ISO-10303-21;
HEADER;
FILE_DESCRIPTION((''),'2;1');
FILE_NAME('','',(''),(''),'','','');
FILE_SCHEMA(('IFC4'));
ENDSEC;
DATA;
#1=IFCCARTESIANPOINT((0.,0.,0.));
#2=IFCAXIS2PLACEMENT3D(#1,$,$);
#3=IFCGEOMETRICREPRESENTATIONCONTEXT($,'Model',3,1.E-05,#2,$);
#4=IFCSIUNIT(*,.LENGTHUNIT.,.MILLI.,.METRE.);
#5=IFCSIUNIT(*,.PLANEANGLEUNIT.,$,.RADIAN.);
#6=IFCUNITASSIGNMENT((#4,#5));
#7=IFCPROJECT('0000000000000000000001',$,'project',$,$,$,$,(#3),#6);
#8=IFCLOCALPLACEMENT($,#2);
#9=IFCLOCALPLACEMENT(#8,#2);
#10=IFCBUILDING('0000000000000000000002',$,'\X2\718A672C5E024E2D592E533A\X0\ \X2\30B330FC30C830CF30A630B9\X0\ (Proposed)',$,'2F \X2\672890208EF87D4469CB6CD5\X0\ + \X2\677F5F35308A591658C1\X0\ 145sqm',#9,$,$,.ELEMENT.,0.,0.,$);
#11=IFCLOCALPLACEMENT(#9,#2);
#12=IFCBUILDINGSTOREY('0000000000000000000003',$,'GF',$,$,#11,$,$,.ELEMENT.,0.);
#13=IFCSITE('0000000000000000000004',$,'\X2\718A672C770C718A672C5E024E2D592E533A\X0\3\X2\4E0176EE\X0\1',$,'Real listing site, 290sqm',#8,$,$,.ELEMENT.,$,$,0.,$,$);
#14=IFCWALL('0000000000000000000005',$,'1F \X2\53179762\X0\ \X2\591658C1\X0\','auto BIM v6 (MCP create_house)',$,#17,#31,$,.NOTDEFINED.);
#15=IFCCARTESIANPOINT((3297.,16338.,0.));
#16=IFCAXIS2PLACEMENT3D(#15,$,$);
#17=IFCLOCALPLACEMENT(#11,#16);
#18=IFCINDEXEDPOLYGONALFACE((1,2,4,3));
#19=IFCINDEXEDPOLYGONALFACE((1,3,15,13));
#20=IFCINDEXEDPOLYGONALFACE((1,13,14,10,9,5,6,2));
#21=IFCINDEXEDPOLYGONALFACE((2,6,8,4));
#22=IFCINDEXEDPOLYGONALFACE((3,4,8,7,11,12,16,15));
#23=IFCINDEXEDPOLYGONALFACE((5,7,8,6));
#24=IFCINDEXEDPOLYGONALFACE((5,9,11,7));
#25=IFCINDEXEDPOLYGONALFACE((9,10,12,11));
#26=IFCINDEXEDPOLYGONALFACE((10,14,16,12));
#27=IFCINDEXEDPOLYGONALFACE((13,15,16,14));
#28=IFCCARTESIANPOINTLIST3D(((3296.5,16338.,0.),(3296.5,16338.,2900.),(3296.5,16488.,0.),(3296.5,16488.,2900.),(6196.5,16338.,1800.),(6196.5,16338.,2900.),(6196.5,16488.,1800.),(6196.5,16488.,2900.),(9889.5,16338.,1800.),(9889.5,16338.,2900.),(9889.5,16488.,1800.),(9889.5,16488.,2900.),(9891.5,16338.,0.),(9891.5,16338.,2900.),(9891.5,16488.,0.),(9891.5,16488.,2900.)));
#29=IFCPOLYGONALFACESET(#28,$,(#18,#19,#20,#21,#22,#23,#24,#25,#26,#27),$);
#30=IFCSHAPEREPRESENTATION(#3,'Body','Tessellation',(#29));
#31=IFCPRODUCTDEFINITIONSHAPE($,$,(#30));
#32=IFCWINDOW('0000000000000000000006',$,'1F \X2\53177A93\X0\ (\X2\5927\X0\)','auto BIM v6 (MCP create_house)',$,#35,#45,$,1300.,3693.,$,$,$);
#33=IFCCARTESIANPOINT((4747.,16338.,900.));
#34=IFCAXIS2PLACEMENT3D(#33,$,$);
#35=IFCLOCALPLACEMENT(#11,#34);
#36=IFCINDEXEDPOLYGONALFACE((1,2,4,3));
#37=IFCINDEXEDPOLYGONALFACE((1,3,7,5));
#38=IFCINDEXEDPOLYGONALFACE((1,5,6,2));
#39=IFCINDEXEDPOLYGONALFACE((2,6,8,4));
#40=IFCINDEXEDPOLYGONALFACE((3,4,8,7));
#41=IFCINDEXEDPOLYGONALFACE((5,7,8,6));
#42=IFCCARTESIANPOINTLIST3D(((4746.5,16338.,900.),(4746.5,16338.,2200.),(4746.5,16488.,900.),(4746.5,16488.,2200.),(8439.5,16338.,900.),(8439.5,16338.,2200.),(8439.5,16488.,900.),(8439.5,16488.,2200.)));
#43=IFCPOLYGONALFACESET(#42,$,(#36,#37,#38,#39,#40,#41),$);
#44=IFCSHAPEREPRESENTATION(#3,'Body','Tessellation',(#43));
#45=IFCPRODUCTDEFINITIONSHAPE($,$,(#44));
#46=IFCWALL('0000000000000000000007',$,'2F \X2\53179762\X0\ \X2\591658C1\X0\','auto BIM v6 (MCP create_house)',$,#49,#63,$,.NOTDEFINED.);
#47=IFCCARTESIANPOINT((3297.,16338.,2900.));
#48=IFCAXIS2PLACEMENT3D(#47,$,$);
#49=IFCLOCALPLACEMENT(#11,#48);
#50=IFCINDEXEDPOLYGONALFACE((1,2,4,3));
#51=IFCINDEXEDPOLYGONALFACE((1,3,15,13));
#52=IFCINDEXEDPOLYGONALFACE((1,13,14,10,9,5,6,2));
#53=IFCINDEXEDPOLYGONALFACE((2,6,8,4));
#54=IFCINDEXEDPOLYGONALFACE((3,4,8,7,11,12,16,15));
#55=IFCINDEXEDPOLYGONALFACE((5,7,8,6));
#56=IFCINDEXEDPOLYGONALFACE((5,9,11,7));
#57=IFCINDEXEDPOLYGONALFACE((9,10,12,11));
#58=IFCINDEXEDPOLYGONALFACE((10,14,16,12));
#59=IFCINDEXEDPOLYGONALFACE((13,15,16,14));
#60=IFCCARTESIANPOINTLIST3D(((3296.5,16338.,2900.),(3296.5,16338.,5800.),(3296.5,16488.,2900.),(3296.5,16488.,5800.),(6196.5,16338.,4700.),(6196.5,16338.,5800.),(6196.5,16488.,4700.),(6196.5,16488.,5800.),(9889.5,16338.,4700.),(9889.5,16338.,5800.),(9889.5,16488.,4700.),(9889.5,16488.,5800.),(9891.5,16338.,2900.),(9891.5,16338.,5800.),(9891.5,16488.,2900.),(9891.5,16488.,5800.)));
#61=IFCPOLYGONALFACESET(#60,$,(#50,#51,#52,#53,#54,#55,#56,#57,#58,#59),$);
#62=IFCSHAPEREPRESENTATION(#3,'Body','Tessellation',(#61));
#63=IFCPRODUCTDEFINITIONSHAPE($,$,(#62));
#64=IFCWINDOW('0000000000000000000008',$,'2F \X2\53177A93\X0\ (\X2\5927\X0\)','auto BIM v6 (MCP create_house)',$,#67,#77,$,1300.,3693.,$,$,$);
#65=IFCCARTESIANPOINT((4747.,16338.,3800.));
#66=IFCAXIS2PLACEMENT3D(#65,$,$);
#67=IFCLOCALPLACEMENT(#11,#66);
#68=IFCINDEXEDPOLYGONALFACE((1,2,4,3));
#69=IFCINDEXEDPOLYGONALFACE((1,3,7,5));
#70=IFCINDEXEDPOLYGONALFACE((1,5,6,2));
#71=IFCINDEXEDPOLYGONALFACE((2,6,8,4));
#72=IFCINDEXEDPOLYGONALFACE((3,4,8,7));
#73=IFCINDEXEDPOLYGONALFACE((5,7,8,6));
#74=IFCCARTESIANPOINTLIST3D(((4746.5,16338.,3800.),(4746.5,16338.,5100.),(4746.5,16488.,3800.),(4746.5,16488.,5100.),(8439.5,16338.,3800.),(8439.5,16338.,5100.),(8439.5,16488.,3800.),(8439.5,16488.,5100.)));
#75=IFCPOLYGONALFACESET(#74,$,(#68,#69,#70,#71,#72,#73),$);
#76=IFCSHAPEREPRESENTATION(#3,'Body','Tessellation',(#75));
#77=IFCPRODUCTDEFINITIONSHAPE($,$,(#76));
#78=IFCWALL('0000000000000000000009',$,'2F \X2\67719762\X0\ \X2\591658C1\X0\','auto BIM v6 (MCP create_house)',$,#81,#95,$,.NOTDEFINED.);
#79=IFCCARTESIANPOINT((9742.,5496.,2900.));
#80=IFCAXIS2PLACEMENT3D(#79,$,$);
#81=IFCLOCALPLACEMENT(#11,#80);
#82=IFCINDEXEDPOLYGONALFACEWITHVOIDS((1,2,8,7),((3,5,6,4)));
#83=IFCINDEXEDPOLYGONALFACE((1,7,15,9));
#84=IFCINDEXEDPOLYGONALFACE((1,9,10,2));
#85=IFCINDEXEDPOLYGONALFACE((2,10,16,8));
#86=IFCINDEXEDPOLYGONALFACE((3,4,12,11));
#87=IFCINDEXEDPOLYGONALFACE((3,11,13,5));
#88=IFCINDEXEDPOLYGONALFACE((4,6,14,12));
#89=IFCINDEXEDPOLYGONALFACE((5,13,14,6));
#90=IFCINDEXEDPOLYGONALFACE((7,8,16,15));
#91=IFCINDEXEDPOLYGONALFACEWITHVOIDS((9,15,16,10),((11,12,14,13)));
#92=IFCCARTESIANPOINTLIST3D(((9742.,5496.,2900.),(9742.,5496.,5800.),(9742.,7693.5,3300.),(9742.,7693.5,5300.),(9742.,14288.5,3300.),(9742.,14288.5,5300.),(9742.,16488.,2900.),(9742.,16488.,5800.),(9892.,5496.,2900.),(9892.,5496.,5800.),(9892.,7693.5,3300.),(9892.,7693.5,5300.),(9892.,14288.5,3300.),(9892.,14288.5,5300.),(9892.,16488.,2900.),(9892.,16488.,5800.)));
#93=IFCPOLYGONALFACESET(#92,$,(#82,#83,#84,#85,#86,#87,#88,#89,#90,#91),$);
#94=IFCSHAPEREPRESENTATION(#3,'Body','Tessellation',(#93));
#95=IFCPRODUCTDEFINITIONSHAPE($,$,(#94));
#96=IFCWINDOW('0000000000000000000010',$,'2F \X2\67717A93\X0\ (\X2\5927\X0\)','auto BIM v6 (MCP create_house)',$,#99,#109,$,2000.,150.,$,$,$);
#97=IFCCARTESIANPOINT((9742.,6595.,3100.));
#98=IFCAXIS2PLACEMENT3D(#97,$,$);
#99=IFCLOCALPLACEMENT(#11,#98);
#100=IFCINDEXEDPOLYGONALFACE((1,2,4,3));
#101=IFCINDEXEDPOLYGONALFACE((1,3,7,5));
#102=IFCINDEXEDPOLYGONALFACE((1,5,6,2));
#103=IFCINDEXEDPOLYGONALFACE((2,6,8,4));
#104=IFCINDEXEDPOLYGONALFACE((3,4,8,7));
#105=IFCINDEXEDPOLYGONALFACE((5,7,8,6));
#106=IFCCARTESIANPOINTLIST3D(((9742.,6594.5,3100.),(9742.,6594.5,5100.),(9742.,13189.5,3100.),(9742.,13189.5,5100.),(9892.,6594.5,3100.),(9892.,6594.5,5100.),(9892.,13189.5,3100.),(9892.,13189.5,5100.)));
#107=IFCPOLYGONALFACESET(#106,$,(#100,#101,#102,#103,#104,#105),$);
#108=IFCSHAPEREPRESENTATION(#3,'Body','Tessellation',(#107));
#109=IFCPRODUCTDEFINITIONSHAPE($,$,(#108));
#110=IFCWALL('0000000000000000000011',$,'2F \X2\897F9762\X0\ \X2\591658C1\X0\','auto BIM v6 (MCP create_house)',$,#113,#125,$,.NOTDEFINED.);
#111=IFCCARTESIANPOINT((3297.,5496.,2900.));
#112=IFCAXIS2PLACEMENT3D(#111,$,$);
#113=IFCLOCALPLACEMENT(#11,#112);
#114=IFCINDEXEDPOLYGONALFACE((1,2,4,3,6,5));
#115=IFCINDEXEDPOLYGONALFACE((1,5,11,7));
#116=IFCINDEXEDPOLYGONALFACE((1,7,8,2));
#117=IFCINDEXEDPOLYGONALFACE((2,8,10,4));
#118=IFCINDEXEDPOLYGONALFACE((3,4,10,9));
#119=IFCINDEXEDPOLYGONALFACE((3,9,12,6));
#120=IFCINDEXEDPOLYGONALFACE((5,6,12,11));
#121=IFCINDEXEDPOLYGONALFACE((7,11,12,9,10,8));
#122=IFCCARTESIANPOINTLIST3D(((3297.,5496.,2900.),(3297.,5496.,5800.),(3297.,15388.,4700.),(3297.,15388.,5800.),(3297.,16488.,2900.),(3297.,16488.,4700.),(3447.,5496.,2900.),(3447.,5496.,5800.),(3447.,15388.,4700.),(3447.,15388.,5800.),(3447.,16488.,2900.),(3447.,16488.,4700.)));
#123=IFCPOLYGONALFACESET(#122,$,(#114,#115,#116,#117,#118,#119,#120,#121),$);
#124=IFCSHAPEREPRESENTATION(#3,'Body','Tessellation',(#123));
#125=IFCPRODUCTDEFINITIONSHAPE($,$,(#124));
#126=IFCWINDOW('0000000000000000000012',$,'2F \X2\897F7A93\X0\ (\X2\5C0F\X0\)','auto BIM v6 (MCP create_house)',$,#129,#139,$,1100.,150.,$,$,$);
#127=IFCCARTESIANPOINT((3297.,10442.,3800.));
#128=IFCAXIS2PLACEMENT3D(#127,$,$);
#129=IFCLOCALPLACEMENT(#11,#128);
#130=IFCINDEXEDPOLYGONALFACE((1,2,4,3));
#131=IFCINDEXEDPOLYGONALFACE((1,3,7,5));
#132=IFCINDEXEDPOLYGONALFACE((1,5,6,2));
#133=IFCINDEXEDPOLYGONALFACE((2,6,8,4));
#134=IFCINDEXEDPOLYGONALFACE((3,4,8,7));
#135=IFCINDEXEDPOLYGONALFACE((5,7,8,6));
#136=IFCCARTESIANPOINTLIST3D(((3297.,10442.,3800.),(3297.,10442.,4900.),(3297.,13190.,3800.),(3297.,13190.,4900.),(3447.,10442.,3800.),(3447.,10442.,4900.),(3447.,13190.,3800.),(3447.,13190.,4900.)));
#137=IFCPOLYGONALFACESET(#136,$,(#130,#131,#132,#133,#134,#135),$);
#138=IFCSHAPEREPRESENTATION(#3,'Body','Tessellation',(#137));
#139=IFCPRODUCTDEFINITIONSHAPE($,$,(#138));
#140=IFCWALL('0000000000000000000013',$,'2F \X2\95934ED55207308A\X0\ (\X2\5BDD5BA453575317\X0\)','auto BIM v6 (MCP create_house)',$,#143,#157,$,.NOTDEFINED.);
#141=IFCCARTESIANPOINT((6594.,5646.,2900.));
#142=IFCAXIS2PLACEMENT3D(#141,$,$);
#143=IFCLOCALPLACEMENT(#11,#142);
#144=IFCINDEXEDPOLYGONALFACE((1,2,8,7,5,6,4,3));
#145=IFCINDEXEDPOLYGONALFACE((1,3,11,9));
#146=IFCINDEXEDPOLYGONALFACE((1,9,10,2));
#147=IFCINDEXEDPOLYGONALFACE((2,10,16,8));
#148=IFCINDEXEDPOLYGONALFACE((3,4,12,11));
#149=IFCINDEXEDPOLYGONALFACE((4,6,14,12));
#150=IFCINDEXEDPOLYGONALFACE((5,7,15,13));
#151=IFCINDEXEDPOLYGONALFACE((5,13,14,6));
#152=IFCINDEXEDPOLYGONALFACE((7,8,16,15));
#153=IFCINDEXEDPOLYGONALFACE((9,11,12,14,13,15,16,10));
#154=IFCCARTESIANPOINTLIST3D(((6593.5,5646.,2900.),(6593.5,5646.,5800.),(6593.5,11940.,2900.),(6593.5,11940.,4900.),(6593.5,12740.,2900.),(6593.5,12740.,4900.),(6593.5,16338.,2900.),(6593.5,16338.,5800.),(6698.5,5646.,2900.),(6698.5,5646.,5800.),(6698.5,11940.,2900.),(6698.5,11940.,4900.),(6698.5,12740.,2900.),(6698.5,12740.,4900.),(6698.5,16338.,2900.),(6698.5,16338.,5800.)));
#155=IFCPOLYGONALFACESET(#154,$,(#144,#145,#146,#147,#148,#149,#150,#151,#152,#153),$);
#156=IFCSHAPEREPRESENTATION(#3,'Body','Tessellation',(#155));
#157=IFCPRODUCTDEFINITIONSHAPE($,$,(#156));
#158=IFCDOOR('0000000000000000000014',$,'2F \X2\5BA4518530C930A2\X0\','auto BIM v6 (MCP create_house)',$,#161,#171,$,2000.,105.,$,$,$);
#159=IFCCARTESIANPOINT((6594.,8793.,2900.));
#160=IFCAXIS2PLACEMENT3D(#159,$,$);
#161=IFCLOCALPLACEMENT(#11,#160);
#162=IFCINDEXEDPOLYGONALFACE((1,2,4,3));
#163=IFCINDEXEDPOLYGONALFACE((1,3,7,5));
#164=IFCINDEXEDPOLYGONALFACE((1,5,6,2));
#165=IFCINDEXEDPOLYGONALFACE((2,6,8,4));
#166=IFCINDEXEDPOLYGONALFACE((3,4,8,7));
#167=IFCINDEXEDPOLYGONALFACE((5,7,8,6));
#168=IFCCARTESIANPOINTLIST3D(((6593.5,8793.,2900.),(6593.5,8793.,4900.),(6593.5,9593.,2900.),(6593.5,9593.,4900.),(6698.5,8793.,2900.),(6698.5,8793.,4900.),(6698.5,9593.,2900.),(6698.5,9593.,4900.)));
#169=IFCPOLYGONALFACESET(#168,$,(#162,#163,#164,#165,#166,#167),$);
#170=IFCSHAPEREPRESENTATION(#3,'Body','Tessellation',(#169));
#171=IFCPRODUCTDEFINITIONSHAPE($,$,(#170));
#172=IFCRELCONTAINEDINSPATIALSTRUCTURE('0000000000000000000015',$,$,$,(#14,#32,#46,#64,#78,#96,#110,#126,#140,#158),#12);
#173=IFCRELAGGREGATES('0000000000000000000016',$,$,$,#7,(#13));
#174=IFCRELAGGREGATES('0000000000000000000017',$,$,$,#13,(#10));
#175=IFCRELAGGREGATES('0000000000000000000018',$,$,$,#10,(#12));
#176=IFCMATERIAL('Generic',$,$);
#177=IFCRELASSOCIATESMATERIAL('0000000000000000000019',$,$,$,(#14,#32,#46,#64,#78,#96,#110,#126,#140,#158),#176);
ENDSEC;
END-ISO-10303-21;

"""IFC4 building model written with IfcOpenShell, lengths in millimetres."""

from ifc_helpers import new_model, si_unit, frame, frame_2d, origin, place, context, project, spatial, rectangle, extrude, material, element, fill, save


model = new_model("IFC4")

# Units and contexts
model_context = context("Model", 3, precision=1e-05, world=origin())
ifc_project = project(units=[si_unit("LENGTHUNIT", "METRE", prefix="MILLI"), si_unit("PLANEANGLEUNIT", "RADIAN")], contexts=[model_context])

# Site, building, storey
site_placement = place(None, origin())
site = spatial("IfcSite", under=ifc_project, at=site_placement, Name="熊本県熊本市中央区3丁目1", ObjectType="Real listing site, 290sqm", CompositionType="ELEMENT", RefElevation=0.0)
building_placement = place(site_placement, origin())
building = spatial("IfcBuilding", under=site, at=building_placement, Name="熊本市中央区 コートハウス (Proposed)", ObjectType="2F 木造軸組構法 + 板張り外壁 145sqm", CompositionType="ELEMENT", ElevationOfRefHeight=0.0, ElevationOfTerrain=0.0)
storey_placement = place(building_placement, origin())
storey = spatial("IfcBuildingStorey", under=building, at=storey_placement, Name="GF", CompositionType="ELEMENT", Elevation=0.0)

# Wall, opening, window
ifc_material = material(Name="Generic")
wall_1_placement = place(storey_placement, frame((3297.0, 16338.0, 0.0)))
wall_1 = element("IfcWall", 1, at=wall_1_placement, inside=storey, material=ifc_material, Name="1F 北面 外壁", Description="auto BIM v6 (MCP create_house)", PredefinedType="NOTDEFINED", context=model_context, shape_type="SweptSolid", body=[
    extrude(rectangle(XDim=6595.0, YDim=150.0, at=frame_2d((3297.0, 75.0))), frame((3297.0, 16338.0, 0.0)), (0.0, 0.0, 1.0), 2900.0),
])
opening_1_placement = place(storey_placement, frame((4747.0, 16338.0, 900.0)))
opening_1 = element("IfcOpeningElement", 2, at=opening_1_placement, cuts=wall_1, PredefinedType="NOTDEFINED", context=model_context, shape_type="SweptSolid", body=[
    extrude(rectangle(XDim=3693.0, YDim=150.0, at=frame_2d((1846.0, 75.0))), frame((4747.0, 16338.0, 900.0)), (0.0, 0.0, 1.0), 1300.0),
])
window_1_placement = place(storey_placement, frame((4747.0, 16338.0, 900.0)))
window_1 = element("IfcWindow", 3, at=window_1_placement, inside=storey, material=ifc_material, Name="1F 北窓 (大)", Description="auto BIM v6 (MCP create_house)", OverallHeight=1300.0, OverallWidth=3693.0, context=model_context, shape_type="SweptSolid", body=[
    extrude(rectangle(XDim=3693.0, YDim=150.0, at=frame_2d((1846.0, 75.0))), frame((4747.0, 16338.0, 900.0)), (0.0, 0.0, 1.0), 1300.0),
])
fill(opening_1, window_1)

# Walls, openings, windows
wall_2_placement = place(storey_placement, frame((3297.0, 16338.0, 2900.0)))
wall_2 = element("IfcWall", 4, at=wall_2_placement, inside=storey, material=ifc_material, Name="2F 北面 外壁", Description="auto BIM v6 (MCP create_house)", PredefinedType="NOTDEFINED", context=model_context, shape_type="SweptSolid", body=[
    extrude(rectangle(XDim=6595.0, YDim=150.0, at=frame_2d((3297.0, 75.0))), frame((3297.0, 16338.0, 2900.0)), (0.0, 0.0, 1.0), 2900.0),
])
opening_2_placement = place(storey_placement, frame((4747.0, 16338.0, 3800.0)))
opening_2 = element("IfcOpeningElement", 5, at=opening_2_placement, cuts=wall_2, PredefinedType="NOTDEFINED", context=model_context, shape_type="SweptSolid", body=[
    extrude(rectangle(XDim=3693.0, YDim=150.0, at=frame_2d((1846.0, 75.0))), frame((4747.0, 16338.0, 3800.0)), (0.0, 0.0, 1.0), 1300.0),
])
window_2_placement = place(storey_placement, frame((4747.0, 16338.0, 3800.0)))
window_2 = element("IfcWindow", 6, at=window_2_placement, inside=storey, material=ifc_material, Name="2F 北窓 (大)", Description="auto BIM v6 (MCP create_house)", OverallHeight=1300.0, OverallWidth=3693.0, context=model_context, shape_type="SweptSolid", body=[
    extrude(rectangle(XDim=3693.0, YDim=150.0, at=frame_2d((1846.0, 75.0))), frame((4747.0, 16338.0, 3800.0)), (0.0, 0.0, 1.0), 1300.0),
])
fill(opening_2, window_2)
wall_3_placement = place(storey_placement, frame((9742.0, 5496.0, 2900.0)))
wall_3 = element("IfcWall", 7, at=wall_3_placement, inside=storey, material=ifc_material, Name="2F 東面 外壁", Description="auto BIM v6 (MCP create_house)", PredefinedType="NOTDEFINED", context=model_context, shape_type="SweptSolid", body=[
    extrude(rectangle(XDim=150.0, YDim=10992.0, at=frame_2d((75.0, 5496.0))), frame((9742.0, 5496.0, 2900.0)), (0.0, 0.0, 1.0), 2900.0),
])
opening_3_placement = place(storey_placement, frame((9742.0, 6595.0, 3100.0)))
opening_3 = element("IfcOpeningElement", 8, at=opening_3_placement, cuts=wall_3, PredefinedType="NOTDEFINED", context=model_context, shape_type="SweptSolid", body=[
    extrude(rectangle(XDim=150.0, YDim=6595.0, at=frame_2d((75.0, 3297.0))), frame((9742.0, 6595.0, 3100.0)), (0.0, 0.0, 1.0), 2000.0),
])
window_3_placement = place(storey_placement, frame((9742.0, 6595.0, 3100.0)))
window_3 = element("IfcWindow", 9, at=window_3_placement, inside=storey, material=ifc_material, Name="2F 東窓 (大)", Description="auto BIM v6 (MCP create_house)", OverallHeight=2000.0, OverallWidth=150.0, context=model_context, shape_type="SweptSolid", body=[
    extrude(rectangle(XDim=150.0, YDim=6595.0, at=frame_2d((75.0, 3297.0))), frame((9742.0, 6595.0, 3100.0)), (0.0, 0.0, 1.0), 2000.0),
])
fill(opening_3, window_3)
wall_4_placement = place(storey_placement, frame((3297.0, 5496.0, 2900.0)))
wall_4 = element("IfcWall", 10, at=wall_4_placement, inside=storey, material=ifc_material, Name="2F 西面 外壁", Description="auto BIM v6 (MCP create_house)", PredefinedType="NOTDEFINED", context=model_context, shape_type="SweptSolid", body=[
    extrude(rectangle(XDim=150.0, YDim=10992.0, at=frame_2d((75.0, 5496.0))), frame((3297.0, 5496.0, 2900.0)), (0.0, 0.0, 1.0), 2900.0),
])
opening_4_placement = place(storey_placement, frame((3297.0, 10442.0, 3800.0)))
opening_4 = element("IfcOpeningElement", 11, at=opening_4_placement, cuts=wall_4, PredefinedType="NOTDEFINED", context=model_context, shape_type="SweptSolid", body=[
    extrude(rectangle(XDim=150.0, YDim=2748.0, at=frame_2d((75.0, 1374.0))), frame((3297.0, 10442.0, 3800.0)), (0.0, 0.0, 1.0), 1100.0),
])
window_4_placement = place(storey_placement, frame((3297.0, 10442.0, 3800.0)))
window_4 = element("IfcWindow", 12, at=window_4_placement, inside=storey, material=ifc_material, Name="2F 西窓 (小)", Description="auto BIM v6 (MCP create_house)", OverallHeight=1100.0, OverallWidth=150.0, context=model_context, shape_type="SweptSolid", body=[
    extrude(rectangle(XDim=150.0, YDim=2748.0, at=frame_2d((75.0, 1374.0))), frame((3297.0, 10442.0, 3800.0)), (0.0, 0.0, 1.0), 1100.0),
])
fill(opening_4, window_4)

# Wall, opening, door
wall_5_placement = place(storey_placement, frame((6594.0, 5646.0, 2900.0)))
wall_5 = element("IfcWall", 13, at=wall_5_placement, inside=storey, material=ifc_material, Name="2F 間仕切り (寝室南北)", Description="auto BIM v6 (MCP create_house)", PredefinedType="NOTDEFINED", context=model_context, shape_type="SweptSolid", body=[
    extrude(rectangle(XDim=105.0, YDim=10692.0, at=frame_2d((52.0, 5346.0))), frame((6594.0, 5646.0, 2900.0)), (0.0, 0.0, 1.0), 2900.0),
])
opening_5_placement = place(storey_placement, frame((6594.0, 8793.0, 2900.0)))
opening_5 = element("IfcOpeningElement", 14, at=opening_5_placement, cuts=wall_5, PredefinedType="NOTDEFINED", context=model_context, shape_type="SweptSolid", body=[
    extrude(rectangle(XDim=105.0, YDim=800.0, at=frame_2d((52.0, 400.0))), frame((6594.0, 8793.0, 2900.0)), (0.0, 0.0, 1.0), 2000.0),
])
door_placement = place(storey_placement, frame((6594.0, 8793.0, 2900.0)))
door = element("IfcDoor", 15, at=door_placement, inside=storey, material=ifc_material, Name="2F 室内ドア", Description="auto BIM v6 (MCP create_house)", OverallHeight=2000.0, OverallWidth=105.0, context=model_context, shape_type="SweptSolid", body=[
    extrude(rectangle(XDim=105.0, YDim=800.0, at=frame_2d((52.0, 400.0))), frame((6594.0, 8793.0, 2900.0)), (0.0, 0.0, 1.0), 2000.0),
])
fill(opening_5, door)

save(model, "model.ifc")
